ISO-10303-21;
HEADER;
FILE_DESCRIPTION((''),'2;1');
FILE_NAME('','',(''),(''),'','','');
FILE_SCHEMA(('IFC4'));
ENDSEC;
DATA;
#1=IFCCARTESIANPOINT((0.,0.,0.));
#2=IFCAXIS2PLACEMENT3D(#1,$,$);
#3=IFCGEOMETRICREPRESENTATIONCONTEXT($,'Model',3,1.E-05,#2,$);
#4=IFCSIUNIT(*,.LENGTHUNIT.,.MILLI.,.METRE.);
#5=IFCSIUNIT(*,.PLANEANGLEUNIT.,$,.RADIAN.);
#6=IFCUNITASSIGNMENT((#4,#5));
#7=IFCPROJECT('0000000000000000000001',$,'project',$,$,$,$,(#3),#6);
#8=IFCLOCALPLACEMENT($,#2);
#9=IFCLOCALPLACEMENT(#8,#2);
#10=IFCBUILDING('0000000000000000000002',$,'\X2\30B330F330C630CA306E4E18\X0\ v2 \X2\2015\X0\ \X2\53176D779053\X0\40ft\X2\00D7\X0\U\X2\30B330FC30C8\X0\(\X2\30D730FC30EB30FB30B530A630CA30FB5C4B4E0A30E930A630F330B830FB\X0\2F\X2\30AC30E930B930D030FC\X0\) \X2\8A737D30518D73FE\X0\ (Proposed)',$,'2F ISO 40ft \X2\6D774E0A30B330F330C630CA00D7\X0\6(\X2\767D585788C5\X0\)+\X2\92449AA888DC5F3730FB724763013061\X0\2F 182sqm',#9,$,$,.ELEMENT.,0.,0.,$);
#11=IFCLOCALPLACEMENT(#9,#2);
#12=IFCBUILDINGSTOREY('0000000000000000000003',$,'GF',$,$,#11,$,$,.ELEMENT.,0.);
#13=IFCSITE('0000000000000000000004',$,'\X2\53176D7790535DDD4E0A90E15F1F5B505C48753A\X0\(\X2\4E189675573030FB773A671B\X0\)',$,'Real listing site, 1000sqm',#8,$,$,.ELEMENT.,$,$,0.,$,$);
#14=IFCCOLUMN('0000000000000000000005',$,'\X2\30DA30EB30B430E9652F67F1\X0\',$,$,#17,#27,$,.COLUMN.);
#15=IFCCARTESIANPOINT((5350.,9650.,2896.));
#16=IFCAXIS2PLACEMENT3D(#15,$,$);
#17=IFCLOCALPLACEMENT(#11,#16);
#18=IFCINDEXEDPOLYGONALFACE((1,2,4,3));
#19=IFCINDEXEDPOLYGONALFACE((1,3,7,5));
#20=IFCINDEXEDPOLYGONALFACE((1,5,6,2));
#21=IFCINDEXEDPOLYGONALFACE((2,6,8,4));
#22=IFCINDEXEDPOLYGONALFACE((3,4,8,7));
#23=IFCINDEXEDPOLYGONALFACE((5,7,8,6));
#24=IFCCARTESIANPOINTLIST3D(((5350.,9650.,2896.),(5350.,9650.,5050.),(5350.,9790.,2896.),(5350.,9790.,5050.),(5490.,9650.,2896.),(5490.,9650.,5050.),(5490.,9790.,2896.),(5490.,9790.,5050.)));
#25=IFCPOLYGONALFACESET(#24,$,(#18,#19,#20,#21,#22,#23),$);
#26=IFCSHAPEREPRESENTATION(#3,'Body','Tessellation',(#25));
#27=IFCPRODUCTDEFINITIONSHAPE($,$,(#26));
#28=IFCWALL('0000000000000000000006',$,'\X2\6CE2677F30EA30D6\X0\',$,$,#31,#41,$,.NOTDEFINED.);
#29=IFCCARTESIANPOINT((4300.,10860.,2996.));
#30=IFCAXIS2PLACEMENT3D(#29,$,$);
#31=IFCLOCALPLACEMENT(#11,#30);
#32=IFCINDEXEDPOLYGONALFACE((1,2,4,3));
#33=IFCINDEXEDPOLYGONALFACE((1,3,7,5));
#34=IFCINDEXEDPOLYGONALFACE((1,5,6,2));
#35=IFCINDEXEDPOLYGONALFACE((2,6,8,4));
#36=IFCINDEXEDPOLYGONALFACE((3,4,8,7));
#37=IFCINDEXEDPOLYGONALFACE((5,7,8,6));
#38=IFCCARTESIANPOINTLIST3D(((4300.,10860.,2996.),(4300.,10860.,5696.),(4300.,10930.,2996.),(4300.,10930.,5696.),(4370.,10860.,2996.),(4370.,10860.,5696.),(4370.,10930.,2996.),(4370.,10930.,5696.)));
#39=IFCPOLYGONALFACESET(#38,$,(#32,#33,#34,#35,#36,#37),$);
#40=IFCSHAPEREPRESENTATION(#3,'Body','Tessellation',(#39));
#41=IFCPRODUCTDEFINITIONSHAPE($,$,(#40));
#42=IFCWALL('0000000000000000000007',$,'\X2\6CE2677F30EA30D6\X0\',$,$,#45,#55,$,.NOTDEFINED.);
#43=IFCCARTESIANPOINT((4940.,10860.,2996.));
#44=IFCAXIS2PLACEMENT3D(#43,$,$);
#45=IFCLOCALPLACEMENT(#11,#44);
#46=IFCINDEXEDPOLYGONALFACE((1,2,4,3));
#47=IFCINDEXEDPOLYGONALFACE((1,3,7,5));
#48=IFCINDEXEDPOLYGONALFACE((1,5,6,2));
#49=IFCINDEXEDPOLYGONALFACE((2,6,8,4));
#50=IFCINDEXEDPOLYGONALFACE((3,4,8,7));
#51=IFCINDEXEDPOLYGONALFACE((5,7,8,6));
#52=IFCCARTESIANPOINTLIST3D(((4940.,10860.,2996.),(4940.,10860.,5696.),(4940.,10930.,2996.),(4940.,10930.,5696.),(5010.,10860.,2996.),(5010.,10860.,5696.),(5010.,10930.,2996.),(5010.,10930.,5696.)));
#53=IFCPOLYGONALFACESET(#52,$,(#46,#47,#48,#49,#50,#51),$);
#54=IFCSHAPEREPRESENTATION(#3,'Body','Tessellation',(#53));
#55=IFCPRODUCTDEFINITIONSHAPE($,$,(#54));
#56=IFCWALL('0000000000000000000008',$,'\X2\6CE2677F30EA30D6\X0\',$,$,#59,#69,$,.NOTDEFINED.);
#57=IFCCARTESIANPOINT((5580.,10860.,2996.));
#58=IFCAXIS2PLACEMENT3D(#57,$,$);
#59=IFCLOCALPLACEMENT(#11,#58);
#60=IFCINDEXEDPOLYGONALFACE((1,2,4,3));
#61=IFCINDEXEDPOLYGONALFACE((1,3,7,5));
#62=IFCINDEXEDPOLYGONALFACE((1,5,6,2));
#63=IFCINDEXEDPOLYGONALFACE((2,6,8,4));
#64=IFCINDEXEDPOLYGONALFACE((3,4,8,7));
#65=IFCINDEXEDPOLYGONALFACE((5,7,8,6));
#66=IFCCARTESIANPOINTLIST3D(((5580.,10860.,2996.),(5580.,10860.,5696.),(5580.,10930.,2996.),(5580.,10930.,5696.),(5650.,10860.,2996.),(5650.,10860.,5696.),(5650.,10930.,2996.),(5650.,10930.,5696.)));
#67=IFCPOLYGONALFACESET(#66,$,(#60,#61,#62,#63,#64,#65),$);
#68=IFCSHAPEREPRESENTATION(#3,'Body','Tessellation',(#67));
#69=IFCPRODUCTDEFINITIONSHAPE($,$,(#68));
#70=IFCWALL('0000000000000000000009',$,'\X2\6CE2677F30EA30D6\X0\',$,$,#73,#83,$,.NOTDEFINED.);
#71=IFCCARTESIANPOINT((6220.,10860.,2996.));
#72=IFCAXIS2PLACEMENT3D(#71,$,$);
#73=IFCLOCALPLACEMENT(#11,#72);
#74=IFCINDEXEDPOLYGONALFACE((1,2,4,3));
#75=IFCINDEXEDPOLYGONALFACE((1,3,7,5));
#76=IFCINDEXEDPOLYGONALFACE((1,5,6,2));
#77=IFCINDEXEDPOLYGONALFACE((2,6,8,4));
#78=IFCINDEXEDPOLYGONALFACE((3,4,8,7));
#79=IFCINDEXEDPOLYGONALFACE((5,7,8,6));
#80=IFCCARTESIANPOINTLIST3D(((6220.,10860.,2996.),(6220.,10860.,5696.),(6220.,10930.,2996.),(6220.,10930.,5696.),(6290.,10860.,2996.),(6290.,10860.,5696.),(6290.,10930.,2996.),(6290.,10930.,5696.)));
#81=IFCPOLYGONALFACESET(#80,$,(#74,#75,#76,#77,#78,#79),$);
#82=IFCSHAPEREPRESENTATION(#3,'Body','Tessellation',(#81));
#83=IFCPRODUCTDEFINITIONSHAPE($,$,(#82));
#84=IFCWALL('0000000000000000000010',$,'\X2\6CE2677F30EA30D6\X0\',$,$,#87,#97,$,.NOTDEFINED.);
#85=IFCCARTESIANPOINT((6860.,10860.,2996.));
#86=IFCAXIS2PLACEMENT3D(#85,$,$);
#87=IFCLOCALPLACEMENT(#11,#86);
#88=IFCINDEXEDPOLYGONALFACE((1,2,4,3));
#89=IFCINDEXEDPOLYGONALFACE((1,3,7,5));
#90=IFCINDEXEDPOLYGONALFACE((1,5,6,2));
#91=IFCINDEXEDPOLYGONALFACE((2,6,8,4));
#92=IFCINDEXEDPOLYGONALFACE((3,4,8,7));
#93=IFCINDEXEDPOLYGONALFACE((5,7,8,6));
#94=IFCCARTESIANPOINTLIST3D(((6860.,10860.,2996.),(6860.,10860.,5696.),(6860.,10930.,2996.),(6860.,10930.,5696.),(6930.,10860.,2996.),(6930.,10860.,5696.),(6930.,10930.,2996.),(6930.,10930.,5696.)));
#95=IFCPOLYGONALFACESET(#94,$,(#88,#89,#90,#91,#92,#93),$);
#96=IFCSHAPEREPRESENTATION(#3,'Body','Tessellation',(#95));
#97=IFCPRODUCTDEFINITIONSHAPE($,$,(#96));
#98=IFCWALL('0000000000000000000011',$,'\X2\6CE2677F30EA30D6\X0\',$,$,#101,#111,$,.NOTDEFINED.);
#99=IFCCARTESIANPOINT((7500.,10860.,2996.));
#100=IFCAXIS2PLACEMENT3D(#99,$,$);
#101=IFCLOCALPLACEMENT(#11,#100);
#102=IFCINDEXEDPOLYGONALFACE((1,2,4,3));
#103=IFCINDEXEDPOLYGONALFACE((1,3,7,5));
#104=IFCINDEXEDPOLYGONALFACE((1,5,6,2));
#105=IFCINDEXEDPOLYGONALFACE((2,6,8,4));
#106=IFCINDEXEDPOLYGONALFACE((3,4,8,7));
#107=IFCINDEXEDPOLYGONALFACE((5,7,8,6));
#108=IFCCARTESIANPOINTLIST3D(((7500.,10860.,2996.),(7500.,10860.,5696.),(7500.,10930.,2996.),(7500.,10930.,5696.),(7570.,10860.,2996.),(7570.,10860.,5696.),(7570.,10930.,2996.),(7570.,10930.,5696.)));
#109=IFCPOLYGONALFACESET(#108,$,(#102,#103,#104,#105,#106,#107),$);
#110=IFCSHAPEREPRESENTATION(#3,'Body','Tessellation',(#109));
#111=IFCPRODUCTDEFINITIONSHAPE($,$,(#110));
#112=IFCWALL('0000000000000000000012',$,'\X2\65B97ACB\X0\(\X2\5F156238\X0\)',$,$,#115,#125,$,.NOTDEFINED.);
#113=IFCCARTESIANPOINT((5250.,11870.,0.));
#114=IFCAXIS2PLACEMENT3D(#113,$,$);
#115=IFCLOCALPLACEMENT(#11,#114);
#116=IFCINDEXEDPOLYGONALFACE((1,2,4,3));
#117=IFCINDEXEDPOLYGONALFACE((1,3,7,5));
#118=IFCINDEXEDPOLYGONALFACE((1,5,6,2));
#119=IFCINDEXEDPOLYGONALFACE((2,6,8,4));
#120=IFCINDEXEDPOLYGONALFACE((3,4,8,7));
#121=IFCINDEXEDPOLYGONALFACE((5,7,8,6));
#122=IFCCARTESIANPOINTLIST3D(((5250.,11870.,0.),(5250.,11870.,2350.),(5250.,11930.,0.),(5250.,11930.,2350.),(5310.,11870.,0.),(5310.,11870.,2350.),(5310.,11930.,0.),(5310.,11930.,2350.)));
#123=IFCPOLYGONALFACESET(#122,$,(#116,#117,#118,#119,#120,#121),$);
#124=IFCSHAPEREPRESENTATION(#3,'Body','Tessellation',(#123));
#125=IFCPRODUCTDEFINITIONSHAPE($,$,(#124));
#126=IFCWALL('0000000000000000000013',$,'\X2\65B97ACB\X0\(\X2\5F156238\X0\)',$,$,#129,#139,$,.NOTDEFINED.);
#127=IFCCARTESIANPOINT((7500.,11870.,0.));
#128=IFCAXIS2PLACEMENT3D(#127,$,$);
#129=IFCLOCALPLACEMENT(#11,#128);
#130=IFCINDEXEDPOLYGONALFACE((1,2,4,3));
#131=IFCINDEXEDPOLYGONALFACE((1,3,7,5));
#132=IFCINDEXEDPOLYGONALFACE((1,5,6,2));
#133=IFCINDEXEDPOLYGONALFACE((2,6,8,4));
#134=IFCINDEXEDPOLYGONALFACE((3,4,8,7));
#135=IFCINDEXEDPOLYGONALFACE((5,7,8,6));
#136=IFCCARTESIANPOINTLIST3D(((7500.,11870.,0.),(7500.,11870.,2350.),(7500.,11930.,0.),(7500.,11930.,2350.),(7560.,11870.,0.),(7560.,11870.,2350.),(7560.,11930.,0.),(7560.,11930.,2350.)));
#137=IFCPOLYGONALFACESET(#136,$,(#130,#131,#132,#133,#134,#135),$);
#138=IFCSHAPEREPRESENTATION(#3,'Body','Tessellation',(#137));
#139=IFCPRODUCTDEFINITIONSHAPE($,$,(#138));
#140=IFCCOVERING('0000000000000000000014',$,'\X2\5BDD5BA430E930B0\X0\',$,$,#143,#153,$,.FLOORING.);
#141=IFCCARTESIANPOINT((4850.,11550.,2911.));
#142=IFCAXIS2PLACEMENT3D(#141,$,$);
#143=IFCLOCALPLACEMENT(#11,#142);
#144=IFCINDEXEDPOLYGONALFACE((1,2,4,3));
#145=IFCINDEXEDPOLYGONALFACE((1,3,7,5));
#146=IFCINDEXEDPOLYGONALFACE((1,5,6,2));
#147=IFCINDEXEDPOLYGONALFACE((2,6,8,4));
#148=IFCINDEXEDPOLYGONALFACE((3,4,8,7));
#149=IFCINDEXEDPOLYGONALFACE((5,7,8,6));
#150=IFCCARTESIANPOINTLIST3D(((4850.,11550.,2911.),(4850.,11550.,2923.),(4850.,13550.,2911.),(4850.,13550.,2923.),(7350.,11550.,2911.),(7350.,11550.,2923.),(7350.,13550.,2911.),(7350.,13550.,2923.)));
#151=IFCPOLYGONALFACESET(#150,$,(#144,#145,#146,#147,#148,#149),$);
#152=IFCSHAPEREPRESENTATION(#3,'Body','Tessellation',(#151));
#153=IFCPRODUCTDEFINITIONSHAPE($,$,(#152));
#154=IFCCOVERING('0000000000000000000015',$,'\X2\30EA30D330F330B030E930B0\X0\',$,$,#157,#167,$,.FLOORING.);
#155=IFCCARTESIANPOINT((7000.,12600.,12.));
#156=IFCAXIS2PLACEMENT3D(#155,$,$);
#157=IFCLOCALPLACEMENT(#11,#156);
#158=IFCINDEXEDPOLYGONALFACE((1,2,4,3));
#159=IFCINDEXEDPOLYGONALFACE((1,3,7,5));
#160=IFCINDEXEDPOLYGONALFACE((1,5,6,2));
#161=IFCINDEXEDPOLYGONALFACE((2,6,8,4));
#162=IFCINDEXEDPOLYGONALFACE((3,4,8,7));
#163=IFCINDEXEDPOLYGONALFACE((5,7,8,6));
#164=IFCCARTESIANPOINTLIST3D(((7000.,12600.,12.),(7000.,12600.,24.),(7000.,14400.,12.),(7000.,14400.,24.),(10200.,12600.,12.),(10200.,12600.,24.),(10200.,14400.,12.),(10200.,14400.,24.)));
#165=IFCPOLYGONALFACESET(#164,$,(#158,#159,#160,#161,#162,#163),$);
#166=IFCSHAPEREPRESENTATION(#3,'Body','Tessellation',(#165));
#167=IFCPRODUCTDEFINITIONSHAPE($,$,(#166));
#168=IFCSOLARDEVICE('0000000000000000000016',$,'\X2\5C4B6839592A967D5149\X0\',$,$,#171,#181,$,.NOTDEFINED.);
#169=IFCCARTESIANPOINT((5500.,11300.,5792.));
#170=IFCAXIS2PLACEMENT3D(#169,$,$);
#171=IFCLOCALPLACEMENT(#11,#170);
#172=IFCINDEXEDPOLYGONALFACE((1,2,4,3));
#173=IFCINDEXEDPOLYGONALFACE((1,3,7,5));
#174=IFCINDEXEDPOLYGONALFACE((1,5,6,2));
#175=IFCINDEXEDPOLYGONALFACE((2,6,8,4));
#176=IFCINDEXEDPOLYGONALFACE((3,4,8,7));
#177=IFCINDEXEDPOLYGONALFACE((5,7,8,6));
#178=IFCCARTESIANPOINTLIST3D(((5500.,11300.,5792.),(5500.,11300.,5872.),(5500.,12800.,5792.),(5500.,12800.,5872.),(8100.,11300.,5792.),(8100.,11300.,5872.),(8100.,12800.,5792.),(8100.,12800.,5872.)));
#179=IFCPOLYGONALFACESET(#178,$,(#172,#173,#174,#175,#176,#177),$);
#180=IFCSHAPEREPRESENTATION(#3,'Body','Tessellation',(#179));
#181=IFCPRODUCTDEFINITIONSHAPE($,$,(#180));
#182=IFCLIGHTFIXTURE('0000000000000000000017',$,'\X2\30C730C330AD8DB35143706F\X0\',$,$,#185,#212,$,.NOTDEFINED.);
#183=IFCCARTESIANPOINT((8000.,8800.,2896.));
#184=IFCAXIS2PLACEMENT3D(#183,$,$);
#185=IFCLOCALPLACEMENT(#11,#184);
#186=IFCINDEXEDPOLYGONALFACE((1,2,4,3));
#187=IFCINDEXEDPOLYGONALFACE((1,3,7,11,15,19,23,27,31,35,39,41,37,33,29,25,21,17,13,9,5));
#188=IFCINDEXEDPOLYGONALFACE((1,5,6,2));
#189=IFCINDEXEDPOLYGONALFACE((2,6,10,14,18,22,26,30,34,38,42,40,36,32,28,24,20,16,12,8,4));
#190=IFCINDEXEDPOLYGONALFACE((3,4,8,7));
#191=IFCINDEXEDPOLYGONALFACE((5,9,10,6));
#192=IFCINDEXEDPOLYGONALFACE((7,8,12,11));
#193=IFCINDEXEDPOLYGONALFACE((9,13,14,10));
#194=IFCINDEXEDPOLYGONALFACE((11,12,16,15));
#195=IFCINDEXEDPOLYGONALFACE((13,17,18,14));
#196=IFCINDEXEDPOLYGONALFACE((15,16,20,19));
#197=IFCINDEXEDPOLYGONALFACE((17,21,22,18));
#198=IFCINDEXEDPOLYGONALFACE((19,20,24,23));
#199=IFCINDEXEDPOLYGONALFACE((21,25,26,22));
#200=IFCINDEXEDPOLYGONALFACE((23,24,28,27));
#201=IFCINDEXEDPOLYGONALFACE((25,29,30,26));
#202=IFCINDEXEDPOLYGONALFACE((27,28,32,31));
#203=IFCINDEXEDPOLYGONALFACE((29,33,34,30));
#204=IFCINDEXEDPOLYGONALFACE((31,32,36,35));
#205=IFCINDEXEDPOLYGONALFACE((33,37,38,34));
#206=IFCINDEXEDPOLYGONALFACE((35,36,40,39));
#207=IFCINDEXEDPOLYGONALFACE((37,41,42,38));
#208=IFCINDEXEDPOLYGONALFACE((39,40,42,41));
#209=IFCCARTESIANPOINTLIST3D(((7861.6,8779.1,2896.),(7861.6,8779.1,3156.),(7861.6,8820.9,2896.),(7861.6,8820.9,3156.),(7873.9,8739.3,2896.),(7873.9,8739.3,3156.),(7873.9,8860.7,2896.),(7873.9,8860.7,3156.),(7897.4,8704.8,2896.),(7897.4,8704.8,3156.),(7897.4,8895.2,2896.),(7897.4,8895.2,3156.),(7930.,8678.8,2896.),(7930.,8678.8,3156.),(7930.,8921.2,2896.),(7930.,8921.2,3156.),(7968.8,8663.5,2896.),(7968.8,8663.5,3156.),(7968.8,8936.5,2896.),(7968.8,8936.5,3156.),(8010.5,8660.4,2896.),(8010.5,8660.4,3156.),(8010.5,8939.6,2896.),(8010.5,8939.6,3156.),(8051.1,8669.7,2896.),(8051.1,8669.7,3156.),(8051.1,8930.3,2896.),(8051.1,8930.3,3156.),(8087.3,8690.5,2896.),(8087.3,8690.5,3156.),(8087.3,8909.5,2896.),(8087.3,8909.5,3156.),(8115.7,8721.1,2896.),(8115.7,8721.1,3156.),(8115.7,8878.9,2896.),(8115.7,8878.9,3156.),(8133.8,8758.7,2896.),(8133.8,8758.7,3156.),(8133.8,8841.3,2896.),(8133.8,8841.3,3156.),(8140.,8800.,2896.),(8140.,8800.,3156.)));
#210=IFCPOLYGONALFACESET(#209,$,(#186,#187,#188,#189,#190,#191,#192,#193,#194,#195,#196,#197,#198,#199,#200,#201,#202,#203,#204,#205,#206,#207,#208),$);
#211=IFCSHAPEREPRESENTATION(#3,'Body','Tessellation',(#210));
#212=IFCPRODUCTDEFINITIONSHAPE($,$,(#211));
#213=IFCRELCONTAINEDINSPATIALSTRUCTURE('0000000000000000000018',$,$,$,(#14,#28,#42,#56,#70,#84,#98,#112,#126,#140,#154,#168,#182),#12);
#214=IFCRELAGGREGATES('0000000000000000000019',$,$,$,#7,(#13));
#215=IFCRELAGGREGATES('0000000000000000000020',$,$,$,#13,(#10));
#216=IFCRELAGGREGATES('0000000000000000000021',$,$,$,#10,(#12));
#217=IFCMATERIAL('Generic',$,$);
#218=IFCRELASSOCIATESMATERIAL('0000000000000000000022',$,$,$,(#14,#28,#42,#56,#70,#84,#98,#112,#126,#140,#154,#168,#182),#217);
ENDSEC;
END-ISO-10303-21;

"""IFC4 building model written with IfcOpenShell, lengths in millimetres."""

from ifc_helpers import new_model, si_unit, frame, frame_2d, origin, origin_2d, place, context, project, spatial, rectangle, circle, extrude, material, element, save


model = new_model("IFC4")

# Units and contexts
model_context = context("Model", 3, precision=1e-05, world=origin())
ifc_project = project(units=[si_unit("LENGTHUNIT", "METRE", prefix="MILLI"), si_unit("PLANEANGLEUNIT", "RADIAN")], contexts=[model_context])

# Site, building, storey
site_placement = place(None, origin())
site = spatial("IfcSite", under=ifc_project, at=site_placement, Name="北海道川上郡弟子屈町(丘陵地・眺望)", ObjectType="Real listing site, 1000sqm", CompositionType="ELEMENT", RefElevation=0.0)
building_placement = place(site_placement, origin())
building = spatial("IfcBuilding", under=site, at=building_placement, Name="コンテナの丘 v2 ― 北海道40ft×Uコート(プール・サウナ・屋上ラウンジ・2Fガラスバー) 詳細再現 (Proposed)", ObjectType="2F ISO 40ft 海上コンテナ×6(白塗装)+鉄骨補強・片持ち2F 182sqm", CompositionType="ELEMENT", ElevationOfRefHeight=0.0, ElevationOfTerrain=0.0)
storey_placement = place(building_placement, origin())
storey = spatial("IfcBuildingStorey", under=building, at=storey_placement, Name="GF", CompositionType="ELEMENT", Elevation=0.0)

# Column
ifc_material = material(Name="Generic")
column_placement = place(storey_placement, frame((5350.0, 9650.0, 2896.0)))
element("IfcColumn", 1, at=column_placement, inside=storey, material=ifc_material, Name="ペルゴラ支柱", PredefinedType="COLUMN", context=model_context, shape_type="SweptSolid", body=[
    extrude(rectangle(XDim=140.0, YDim=140.0, at=frame_2d((70.0, 70.0))), frame((5350.0, 9650.0, 2896.0)), (0.0, 0.0, 1.0), 2154.0),
])

# Walls
wall_1_placement = place(storey_placement, frame((4300.0, 10860.0, 2996.0)))
element("IfcWall", 2, at=wall_1_placement, inside=storey, material=ifc_material, Name="波板リブ", PredefinedType="NOTDEFINED", context=model_context, shape_type="SweptSolid", body=[
    extrude(rectangle(XDim=70.0, YDim=70.0, at=frame_2d((35.0, 35.0))), frame((4300.0, 10860.0, 2996.0)), (0.0, 0.0, 1.0), 2700.0),
])
wall_2_placement = place(storey_placement, frame((4940.0, 10860.0, 2996.0)))
element("IfcWall", 3, at=wall_2_placement, inside=storey, material=ifc_material, Name="波板リブ", PredefinedType="NOTDEFINED", context=model_context, shape_type="SweptSolid", body=[
    extrude(rectangle(XDim=70.0, YDim=70.0, at=frame_2d((35.0, 35.0))), frame((4940.0, 10860.0, 2996.0)), (0.0, 0.0, 1.0), 2700.0),
])
wall_3_placement = place(storey_placement, frame((5580.0, 10860.0, 2996.0)))
element("IfcWall", 4, at=wall_3_placement, inside=storey, material=ifc_material, Name="波板リブ", PredefinedType="NOTDEFINED", context=model_context, shape_type="SweptSolid", body=[
    extrude(rectangle(XDim=70.0, YDim=70.0, at=frame_2d((35.0, 35.0))), frame((5580.0, 10860.0, 2996.0)), (0.0, 0.0, 1.0), 2700.0),
])
wall_4_placement = place(storey_placement, frame((6220.0, 10860.0, 2996.0)))
element("IfcWall", 5, at=wall_4_placement, inside=storey, material=ifc_material, Name="波板リブ", PredefinedType="NOTDEFINED", context=model_context, shape_type="SweptSolid", body=[
    extrude(rectangle(XDim=70.0, YDim=70.0, at=frame_2d((35.0, 35.0))), frame((6220.0, 10860.0, 2996.0)), (0.0, 0.0, 1.0), 2700.0),
])
wall_5_placement = place(storey_placement, frame((6860.0, 10860.0, 2996.0)))
element("IfcWall", 6, at=wall_5_placement, inside=storey, material=ifc_material, Name="波板リブ", PredefinedType="NOTDEFINED", context=model_context, shape_type="SweptSolid", body=[
    extrude(rectangle(XDim=70.0, YDim=70.0, at=frame_2d((35.0, 35.0))), frame((6860.0, 10860.0, 2996.0)), (0.0, 0.0, 1.0), 2700.0),
])
wall_6_placement = place(storey_placement, frame((7500.0, 10860.0, 2996.0)))
element("IfcWall", 7, at=wall_6_placement, inside=storey, material=ifc_material, Name="波板リブ", PredefinedType="NOTDEFINED", context=model_context, shape_type="SweptSolid", body=[
    extrude(rectangle(XDim=70.0, YDim=70.0, at=frame_2d((35.0, 35.0))), frame((7500.0, 10860.0, 2996.0)), (0.0, 0.0, 1.0), 2700.0),
])
wall_7_placement = place(storey_placement, frame((5250.0, 11870.0, 0.0)))
element("IfcWall", 8, at=wall_7_placement, inside=storey, material=ifc_material, Name="方立(引戸)", PredefinedType="NOTDEFINED", context=model_context, shape_type="SweptSolid", body=[
    extrude(rectangle(XDim=60.0, YDim=60.0, at=frame_2d((30.0, 30.0))), frame((5250.0, 11870.0, 0.0)), (0.0, 0.0, 1.0), 2350.0),
])
wall_8_placement = place(storey_placement, frame((7500.0, 11870.0, 0.0)))
element("IfcWall", 9, at=wall_8_placement, inside=storey, material=ifc_material, Name="方立(引戸)", PredefinedType="NOTDEFINED", context=model_context, shape_type="SweptSolid", body=[
    extrude(rectangle(XDim=60.0, YDim=60.0, at=frame_2d((30.0, 30.0))), frame((7500.0, 11870.0, 0.0)), (0.0, 0.0, 1.0), 2350.0),
])

# Coverings
covering_1_placement = place(storey_placement, frame((4850.0, 11550.0, 2911.0)))
element("IfcCovering", 10, at=covering_1_placement, inside=storey, material=ifc_material, Name="寝室ラグ", PredefinedType="FLOORING", context=model_context, shape_type="SweptSolid", body=[
    extrude(rectangle(XDim=2500.0, YDim=2000.0, at=frame_2d((1250.0, 1000.0))), frame((4850.0, 11550.0, 2911.0)), (0.0, 0.0, 1.0), 12.0),
])
covering_2_placement = place(storey_placement, frame((7000.0, 12600.0, 12.0)))
element("IfcCovering", 11, at=covering_2_placement, inside=storey, material=ifc_material, Name="リビングラグ", PredefinedType="FLOORING", context=model_context, shape_type="SweptSolid", body=[
    extrude(rectangle(XDim=3200.0, YDim=1800.0, at=frame_2d((1600.0, 900.0))), frame((7000.0, 12600.0, 12.0)), (0.0, 0.0, 1.0), 12.0),
])

# Solar device
solar_device_1_placement = place(storey_placement, frame((5500.0, 11300.0, 5792.0)))
element("IfcSolarDevice", 12, at=solar_device_1_placement, inside=storey, material=ifc_material, Name="屋根太陽光", PredefinedType="NOTDEFINED", context=model_context, shape_type="SweptSolid", body=[
    extrude(rectangle(XDim=2600.0, YDim=1500.0, at=frame_2d((1300.0, 750.0))), frame((5500.0, 11300.0, 5792.0)), (0.0, 0.0, 1.0), 80.0),
])

# Light fixture
light_fixture_1_placement = place(storey_placement, frame((8000.0, 8800.0, 2896.0)))
element("IfcLightFixture", 13, at=light_fixture_1_placement, inside=storey, material=ifc_material, Name="デッキ足元灯", PredefinedType="NOTDEFINED", context=model_context, shape_type="SweptSolid", body=[
    extrude(circle(Radius=140.0, at=origin_2d()), frame((8000.0, 8800.0, 2896.0)), (0.0, 0.0, 1.0), 260.0),
])

save(model, "model.ifc")
